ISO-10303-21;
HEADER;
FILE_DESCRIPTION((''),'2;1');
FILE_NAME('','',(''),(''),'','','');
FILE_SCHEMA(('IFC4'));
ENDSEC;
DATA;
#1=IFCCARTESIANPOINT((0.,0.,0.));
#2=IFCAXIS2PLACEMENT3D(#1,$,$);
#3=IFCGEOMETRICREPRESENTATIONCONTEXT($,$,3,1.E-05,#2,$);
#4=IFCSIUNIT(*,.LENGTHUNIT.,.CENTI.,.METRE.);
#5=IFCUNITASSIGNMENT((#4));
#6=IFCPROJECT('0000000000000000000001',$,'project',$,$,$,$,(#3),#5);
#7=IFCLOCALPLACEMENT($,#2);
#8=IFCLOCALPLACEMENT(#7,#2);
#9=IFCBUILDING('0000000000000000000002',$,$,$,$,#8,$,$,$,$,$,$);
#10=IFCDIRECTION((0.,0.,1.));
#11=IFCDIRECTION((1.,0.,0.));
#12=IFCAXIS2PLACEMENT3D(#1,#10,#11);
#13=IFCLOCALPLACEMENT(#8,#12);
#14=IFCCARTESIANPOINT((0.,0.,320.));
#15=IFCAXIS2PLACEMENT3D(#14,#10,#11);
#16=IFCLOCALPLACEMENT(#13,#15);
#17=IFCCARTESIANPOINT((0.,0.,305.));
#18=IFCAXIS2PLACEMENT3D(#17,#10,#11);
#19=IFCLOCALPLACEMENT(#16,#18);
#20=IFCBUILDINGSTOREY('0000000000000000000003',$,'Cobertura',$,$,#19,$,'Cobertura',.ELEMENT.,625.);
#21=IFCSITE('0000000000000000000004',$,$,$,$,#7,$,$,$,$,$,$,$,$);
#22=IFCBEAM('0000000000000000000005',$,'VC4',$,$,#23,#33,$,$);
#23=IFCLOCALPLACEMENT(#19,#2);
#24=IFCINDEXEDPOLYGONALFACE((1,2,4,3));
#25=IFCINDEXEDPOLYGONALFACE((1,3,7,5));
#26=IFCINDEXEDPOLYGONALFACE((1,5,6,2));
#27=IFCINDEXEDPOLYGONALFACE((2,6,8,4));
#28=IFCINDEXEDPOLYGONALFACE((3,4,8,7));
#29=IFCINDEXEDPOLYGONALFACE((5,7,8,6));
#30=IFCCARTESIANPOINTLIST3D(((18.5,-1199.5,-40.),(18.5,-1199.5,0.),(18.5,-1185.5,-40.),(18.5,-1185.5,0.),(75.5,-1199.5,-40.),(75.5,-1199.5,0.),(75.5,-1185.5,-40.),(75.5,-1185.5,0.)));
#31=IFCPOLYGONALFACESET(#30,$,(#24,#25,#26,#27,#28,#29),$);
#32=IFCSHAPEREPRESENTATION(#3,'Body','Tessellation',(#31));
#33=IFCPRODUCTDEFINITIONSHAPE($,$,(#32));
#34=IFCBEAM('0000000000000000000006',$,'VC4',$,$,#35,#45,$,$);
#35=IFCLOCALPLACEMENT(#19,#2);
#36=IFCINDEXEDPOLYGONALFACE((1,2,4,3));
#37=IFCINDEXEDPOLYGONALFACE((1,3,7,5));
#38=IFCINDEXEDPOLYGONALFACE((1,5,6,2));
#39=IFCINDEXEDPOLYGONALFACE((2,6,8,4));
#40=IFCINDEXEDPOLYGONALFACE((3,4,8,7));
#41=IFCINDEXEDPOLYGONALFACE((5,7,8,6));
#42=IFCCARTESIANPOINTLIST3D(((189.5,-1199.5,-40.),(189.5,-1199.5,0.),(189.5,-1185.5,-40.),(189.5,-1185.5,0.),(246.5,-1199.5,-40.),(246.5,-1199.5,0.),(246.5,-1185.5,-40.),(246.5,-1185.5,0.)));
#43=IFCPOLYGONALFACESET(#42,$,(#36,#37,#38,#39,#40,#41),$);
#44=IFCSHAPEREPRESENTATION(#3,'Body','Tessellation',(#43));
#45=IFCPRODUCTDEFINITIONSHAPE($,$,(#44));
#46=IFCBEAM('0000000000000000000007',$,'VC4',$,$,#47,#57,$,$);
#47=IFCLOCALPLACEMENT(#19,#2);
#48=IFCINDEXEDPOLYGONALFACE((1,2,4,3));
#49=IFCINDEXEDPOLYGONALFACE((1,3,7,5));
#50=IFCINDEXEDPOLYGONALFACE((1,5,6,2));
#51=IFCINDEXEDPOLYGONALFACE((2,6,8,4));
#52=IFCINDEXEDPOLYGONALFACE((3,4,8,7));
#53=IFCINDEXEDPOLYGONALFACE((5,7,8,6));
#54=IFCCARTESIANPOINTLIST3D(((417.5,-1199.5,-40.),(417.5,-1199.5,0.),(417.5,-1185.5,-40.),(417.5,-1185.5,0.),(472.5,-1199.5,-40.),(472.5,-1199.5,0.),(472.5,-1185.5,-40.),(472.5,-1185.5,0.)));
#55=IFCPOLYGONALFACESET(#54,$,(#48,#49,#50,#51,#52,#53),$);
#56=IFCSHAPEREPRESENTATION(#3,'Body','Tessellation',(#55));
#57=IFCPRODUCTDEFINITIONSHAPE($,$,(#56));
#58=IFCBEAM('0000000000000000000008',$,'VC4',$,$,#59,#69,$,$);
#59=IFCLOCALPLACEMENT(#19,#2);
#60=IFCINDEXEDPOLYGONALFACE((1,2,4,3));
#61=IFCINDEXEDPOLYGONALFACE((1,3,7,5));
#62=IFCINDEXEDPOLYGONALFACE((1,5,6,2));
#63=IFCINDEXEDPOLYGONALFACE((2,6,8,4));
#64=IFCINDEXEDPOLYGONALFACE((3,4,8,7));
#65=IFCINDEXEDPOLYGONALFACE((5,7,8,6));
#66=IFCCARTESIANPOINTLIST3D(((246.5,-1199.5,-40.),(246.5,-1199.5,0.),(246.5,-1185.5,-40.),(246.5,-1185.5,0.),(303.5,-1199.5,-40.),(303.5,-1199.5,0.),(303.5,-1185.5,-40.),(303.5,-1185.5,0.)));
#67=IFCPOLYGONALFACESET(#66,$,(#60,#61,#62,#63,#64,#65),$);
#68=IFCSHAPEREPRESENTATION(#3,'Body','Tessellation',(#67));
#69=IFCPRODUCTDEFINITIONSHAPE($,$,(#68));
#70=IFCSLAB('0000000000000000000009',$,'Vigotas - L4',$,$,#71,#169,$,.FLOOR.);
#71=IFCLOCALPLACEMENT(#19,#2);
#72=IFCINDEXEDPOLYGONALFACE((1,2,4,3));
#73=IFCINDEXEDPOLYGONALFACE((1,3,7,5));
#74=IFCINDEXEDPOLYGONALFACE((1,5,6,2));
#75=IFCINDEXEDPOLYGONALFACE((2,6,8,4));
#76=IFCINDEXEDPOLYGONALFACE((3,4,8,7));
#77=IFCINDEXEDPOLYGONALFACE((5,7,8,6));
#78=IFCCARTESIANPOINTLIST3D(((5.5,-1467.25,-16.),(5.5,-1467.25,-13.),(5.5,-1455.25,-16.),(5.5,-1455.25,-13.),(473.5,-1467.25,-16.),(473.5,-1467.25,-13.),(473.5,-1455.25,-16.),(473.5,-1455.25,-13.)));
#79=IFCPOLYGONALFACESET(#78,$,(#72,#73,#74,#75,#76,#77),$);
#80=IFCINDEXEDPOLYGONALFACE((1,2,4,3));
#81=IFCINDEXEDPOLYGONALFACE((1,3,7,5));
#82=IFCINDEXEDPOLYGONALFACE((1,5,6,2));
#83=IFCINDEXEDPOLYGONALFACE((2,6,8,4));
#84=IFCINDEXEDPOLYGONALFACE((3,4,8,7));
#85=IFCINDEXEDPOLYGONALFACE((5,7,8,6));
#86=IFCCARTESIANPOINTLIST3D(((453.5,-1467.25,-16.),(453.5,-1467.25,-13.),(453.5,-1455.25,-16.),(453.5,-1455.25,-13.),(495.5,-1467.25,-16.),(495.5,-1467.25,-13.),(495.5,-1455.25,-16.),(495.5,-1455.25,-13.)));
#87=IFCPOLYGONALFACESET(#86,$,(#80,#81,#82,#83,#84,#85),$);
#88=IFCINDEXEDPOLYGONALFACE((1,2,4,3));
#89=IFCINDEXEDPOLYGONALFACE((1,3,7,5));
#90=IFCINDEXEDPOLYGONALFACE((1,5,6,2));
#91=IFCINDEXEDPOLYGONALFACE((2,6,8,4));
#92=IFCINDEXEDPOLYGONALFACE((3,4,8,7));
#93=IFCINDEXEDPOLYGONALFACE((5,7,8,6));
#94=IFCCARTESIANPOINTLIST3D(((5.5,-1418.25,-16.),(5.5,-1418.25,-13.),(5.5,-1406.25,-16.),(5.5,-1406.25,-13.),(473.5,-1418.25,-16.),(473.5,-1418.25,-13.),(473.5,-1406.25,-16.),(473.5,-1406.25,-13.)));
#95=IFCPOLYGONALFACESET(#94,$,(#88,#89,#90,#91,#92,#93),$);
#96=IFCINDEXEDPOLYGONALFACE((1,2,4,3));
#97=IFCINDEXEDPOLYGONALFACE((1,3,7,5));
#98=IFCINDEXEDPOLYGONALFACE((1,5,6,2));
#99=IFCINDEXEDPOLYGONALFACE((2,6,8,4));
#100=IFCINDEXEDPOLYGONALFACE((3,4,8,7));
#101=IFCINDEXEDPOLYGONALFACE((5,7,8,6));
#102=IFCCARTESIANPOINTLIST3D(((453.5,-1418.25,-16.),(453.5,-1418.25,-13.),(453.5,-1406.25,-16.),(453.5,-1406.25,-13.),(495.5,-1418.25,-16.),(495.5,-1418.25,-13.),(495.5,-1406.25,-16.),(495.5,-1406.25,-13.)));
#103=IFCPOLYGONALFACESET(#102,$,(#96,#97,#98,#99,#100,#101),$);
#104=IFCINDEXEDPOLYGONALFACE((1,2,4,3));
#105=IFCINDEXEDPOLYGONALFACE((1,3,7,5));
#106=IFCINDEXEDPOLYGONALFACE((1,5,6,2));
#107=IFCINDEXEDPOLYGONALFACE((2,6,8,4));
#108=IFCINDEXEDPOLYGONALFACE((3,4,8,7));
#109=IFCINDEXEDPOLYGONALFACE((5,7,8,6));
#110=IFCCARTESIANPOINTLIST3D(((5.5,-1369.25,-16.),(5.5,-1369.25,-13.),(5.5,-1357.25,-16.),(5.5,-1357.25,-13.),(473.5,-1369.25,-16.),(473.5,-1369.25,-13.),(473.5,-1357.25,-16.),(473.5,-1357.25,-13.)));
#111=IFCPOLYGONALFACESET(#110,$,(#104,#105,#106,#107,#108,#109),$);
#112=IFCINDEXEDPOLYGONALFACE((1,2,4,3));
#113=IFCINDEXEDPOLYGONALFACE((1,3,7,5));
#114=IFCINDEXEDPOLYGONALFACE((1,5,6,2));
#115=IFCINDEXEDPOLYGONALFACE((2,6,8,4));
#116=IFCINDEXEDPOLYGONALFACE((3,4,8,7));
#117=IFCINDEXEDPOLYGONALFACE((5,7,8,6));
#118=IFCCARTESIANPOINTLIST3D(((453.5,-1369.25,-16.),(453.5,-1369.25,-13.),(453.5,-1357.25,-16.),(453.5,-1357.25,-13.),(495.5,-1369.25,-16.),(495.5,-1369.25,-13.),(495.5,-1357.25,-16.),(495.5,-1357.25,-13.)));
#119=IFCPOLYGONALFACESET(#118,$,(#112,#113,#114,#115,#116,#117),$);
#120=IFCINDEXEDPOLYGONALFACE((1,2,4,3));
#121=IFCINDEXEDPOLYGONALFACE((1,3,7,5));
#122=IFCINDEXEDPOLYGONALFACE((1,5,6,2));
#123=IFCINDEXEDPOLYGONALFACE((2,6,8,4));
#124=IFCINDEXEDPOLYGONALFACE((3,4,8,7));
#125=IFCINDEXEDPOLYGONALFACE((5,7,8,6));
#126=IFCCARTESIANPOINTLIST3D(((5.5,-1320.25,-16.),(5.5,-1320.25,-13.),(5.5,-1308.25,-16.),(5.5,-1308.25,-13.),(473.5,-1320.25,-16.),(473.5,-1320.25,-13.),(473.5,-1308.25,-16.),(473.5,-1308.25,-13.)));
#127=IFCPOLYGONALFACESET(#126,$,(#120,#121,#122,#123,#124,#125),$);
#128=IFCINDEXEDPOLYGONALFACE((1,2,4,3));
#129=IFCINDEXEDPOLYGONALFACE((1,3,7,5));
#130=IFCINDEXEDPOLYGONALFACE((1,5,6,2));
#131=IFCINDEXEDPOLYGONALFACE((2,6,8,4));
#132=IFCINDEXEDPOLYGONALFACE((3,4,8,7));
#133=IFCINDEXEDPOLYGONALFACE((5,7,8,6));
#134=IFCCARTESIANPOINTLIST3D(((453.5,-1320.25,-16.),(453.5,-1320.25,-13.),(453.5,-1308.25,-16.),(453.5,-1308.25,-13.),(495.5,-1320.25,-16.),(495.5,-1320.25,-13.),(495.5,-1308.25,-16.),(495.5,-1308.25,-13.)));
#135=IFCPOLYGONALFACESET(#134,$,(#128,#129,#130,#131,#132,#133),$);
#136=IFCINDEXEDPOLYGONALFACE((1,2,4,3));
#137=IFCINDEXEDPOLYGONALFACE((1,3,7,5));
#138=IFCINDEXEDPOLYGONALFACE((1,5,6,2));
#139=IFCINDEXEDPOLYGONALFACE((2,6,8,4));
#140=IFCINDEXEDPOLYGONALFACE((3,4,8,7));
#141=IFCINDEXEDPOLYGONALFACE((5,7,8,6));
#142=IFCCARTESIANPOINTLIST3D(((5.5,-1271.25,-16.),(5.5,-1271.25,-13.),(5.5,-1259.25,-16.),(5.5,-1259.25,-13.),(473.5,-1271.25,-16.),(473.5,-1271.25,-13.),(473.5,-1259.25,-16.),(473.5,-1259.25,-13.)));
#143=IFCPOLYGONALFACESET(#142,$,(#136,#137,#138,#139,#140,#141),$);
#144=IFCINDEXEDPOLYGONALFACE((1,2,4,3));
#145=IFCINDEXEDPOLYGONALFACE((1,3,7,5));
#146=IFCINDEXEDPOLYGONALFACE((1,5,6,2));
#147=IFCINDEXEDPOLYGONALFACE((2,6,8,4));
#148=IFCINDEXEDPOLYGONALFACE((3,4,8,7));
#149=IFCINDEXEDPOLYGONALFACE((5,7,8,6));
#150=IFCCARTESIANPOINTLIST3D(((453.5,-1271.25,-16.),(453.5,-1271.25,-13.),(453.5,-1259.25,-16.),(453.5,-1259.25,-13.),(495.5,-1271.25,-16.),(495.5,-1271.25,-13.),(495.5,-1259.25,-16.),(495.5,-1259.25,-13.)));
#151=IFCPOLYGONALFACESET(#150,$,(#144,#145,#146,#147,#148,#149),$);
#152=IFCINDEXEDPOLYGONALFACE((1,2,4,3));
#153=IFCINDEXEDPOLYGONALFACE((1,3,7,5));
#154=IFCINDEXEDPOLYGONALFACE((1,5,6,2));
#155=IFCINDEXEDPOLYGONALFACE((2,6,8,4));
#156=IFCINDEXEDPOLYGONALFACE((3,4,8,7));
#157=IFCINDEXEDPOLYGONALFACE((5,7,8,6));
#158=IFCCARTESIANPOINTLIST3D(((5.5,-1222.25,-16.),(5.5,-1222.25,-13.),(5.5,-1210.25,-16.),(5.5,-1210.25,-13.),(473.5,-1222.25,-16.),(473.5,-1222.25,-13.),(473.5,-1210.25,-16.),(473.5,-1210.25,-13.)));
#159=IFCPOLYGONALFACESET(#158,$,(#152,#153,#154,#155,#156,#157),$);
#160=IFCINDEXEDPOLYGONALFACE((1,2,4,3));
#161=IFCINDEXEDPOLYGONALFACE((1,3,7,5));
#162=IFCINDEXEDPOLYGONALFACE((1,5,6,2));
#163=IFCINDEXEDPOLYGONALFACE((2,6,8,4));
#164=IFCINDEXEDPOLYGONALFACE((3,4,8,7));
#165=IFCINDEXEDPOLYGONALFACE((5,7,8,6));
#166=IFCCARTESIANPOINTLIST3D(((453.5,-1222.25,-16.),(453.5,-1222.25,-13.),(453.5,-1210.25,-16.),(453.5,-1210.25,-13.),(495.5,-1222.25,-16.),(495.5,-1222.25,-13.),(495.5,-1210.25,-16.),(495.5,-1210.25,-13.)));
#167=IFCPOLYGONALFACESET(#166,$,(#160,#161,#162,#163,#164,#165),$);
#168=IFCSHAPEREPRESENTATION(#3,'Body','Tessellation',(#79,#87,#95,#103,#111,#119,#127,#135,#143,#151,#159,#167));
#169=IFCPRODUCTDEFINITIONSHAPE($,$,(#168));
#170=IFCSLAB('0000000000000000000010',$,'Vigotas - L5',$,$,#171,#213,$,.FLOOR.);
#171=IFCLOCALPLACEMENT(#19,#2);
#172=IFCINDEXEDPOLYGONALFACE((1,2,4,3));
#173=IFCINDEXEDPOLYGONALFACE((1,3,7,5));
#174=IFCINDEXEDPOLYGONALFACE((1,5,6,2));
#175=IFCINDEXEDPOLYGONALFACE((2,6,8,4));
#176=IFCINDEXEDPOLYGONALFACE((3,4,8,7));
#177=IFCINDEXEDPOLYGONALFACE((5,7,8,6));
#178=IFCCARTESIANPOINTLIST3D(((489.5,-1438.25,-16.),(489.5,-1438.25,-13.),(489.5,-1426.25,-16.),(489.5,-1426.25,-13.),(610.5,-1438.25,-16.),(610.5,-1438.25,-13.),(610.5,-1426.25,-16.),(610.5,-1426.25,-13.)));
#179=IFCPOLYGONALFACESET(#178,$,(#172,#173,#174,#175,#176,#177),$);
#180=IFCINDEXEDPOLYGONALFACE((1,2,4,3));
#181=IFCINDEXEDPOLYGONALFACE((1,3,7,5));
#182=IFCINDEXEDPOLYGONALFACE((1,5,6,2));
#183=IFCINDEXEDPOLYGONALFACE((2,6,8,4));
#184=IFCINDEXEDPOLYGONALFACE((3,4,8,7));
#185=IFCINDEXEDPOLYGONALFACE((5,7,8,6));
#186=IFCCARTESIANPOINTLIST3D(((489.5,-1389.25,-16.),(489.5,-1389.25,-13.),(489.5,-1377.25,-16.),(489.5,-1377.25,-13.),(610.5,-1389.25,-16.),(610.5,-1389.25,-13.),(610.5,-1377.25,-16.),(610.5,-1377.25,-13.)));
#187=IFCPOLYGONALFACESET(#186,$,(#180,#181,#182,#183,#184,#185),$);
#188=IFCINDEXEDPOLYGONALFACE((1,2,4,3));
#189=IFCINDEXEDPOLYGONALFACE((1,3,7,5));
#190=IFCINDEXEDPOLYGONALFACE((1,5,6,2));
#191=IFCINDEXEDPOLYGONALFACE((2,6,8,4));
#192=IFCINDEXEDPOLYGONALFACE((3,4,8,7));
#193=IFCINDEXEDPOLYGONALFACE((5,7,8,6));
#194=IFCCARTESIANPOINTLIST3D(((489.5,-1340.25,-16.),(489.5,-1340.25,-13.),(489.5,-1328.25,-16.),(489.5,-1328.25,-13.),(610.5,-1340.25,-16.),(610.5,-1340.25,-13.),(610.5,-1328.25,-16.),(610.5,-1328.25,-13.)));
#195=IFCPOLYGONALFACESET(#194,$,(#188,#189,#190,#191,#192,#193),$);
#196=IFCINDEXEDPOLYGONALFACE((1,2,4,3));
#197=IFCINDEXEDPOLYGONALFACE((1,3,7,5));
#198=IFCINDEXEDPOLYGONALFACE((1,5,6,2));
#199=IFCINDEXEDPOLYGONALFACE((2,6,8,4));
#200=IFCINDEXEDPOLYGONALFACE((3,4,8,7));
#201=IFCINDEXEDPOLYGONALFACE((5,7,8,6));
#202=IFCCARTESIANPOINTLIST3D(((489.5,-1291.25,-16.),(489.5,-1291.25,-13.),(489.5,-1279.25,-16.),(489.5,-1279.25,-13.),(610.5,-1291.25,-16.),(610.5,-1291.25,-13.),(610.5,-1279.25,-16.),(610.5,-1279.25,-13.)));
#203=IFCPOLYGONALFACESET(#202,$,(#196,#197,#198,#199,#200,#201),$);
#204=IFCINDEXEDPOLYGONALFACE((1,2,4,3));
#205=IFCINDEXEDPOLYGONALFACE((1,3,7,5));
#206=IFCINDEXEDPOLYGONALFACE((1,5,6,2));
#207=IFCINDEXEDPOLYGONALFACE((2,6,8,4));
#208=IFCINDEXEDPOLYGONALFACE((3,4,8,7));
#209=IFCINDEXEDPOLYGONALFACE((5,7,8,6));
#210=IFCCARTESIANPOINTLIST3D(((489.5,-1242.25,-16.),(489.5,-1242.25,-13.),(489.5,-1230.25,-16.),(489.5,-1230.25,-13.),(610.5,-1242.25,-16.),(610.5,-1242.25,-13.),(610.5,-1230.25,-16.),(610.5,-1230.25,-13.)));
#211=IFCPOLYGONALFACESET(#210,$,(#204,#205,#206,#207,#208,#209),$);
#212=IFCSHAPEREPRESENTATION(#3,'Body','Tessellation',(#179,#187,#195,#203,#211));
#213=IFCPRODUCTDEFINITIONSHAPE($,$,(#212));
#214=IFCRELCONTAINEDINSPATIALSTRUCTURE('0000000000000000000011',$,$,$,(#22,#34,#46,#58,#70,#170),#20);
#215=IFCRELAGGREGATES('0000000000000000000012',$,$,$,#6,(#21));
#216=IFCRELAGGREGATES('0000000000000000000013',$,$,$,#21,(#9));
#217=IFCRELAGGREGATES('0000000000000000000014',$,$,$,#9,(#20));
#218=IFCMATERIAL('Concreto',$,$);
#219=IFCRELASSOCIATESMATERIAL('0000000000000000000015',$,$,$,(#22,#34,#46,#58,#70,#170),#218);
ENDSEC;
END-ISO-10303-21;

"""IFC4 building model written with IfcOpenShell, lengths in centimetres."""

from ifc_helpers import new_model, si_unit, frame, origin, origin_with_axes, place, context, project, spatial, polyline, outline, extrude, material, element, save


model = new_model("IFC4")

# Units and contexts
context_of_model = context(None, 3, precision=1e-05, world=origin())
ifc_project = project(units=[si_unit("LENGTHUNIT", "METRE", prefix="CENTI")], contexts=[context_of_model])

# Site, building, storey
site_placement = place(None, origin())
site = spatial("IfcSite", under=ifc_project, at=site_placement)
building_placement = place(site_placement, origin())
building = spatial("IfcBuilding", under=site, at=building_placement)
placement_1 = place(building_placement, origin_with_axes())
placement_2 = place(placement_1, frame((0.0, 0.0, 320.0), z_axis=(0.0, 0.0, 1.0), x_axis=(1.0, 0.0, 0.0)))
storey_placement = place(placement_2, frame((0.0, 0.0, 305.0), z_axis=(0.0, 0.0, 1.0), x_axis=(1.0, 0.0, 0.0)))
storey = spatial("IfcBuildingStorey", under=building, at=storey_placement, Name="Cobertura", LongName="Cobertura", CompositionType="ELEMENT", Elevation=625.0)

# Shared definitions
ifc_material_1 = material(Name="Concreto")

# Beams
for number, where, z_axis, x_axis, name in (
    (1, (47.0, -1192.5, 0.0), (0.0, 0.0, 1.0), (1.0, 0.0, 0.0), "VC4"),
    (2, (218.0, -1192.5, 0.0), (0.0, 0.0, 1.0), (1.0, 0.0, 0.0), "VC4"),
):
    element("IfcBeam", number, at=place(storey_placement, frame(where, z_axis=z_axis, x_axis=x_axis)), inside=storey, material=ifc_material_1, Name=name, context=context_of_model, shape_type="SolidModel", body=[
        extrude(outline(polyline([(-7.0, -20.0), (7.0, -20.0), (7.0, 20.0), (-7.0, 20.0), (-7.0, -20.0)])), frame((-28.5, 0.0, -20.0), z_axis=(1.0, 0.0, 0.0), x_axis=(0.0, -1.0, 0.0)), (0.0, 0.0, 1.0), 57.0),
    ])
beam_1_placement = place(storey_placement, frame((445.0, -1192.5, 0.0), z_axis=(0.0, 0.0, 1.0), x_axis=(1.0, 0.0, 0.0)))
element("IfcBeam", 3, at=beam_1_placement, inside=storey, material=ifc_material_1, Name="VC4", context=context_of_model, shape_type="SolidModel", body=[
    extrude(outline(polyline([(-7.0, -20.0), (7.0, -20.0), (7.0, 20.0), (-7.0, 20.0), (-7.0, -20.0)])), frame((-27.5, 0.0, -20.0), z_axis=(1.0, 0.0, 0.0), x_axis=(0.0, -1.0, 0.0)), (0.0, 0.0, 1.0), 55.0),
])
beam_2_placement = place(storey_placement, frame((275.0, -1192.5, 0.0), z_axis=(0.0, 0.0, 1.0), x_axis=(1.0, 0.0, 0.0)))
element("IfcBeam", 4, at=beam_2_placement, inside=storey, material=ifc_material_1, Name="VC4", context=context_of_model, shape_type="SolidModel", body=[
    extrude(outline(polyline([(-7.0, -20.0), (7.0, -20.0), (7.0, 20.0), (-7.0, 20.0), (-7.0, -20.0)])), frame((-28.5, 0.0, -20.0), z_axis=(1.0, 0.0, 0.0), x_axis=(0.0, -1.0, 0.0)), (0.0, 0.0, 1.0), 57.0),
])

# Slabs
slab_1_placement = place(storey_placement, frame((250.5, -1338.75, -13.0), z_axis=(0.0, 0.0, 1.0), x_axis=(1.0, 0.0, 0.0)))
element("IfcSlab", 5, at=slab_1_placement, inside=storey, material=ifc_material_1, Name="Vigotas - L4", PredefinedType="FLOOR", context=context_of_model, shape_type="SolidModel", body=[
    extrude(outline(polyline([(6.0, 1.5), (-6.0, 1.5), (-6.0, -1.5), (6.0, -1.5), (6.0, 1.5), (6.0, 1.5)])), frame((-245.0, -122.5, -1.5), z_axis=(1.0, 0.0, 0.0), x_axis=(0.0, -1.0, 0.0)), (0.0, 0.0, 1.0), 468.0),
    extrude(outline(polyline([(6.0, 1.5), (-6.0, 1.5), (-6.0, -1.5), (6.0, -1.5), (6.0, 1.5), (6.0, 1.5)])), frame((203.0, -122.5, -1.5), z_axis=(1.0, 0.0, 0.0), x_axis=(0.0, -1.0, 0.0)), (0.0, 0.0, 1.0), 42.0),
    extrude(outline(polyline([(6.0, 1.5), (-6.0, 1.5), (-6.0, -1.5), (6.0, -1.5), (6.0, 1.5), (6.0, 1.5)])), frame((-245.0, -73.5, -1.5), z_axis=(1.0, 0.0, 0.0), x_axis=(0.0, -1.0, 0.0)), (0.0, 0.0, 1.0), 468.0),
    extrude(outline(polyline([(6.0, 1.5), (-6.0, 1.5), (-6.0, -1.5), (6.0, -1.5), (6.0, 1.5), (6.0, 1.5)])), frame((203.0, -73.5, -1.5), z_axis=(1.0, 0.0, 0.0), x_axis=(0.0, -1.0, 0.0)), (0.0, 0.0, 1.0), 42.0),
    extrude(outline(polyline([(6.0, 1.5), (-6.0, 1.5), (-6.0, -1.5), (6.0, -1.5), (6.0, 1.5), (6.0, 1.5)])), frame((-245.0, -24.5, -1.5), z_axis=(1.0, 0.0, 0.0), x_axis=(0.0, -1.0, 0.0)), (0.0, 0.0, 1.0), 468.0),
    extrude(outline(polyline([(6.0, 1.5), (-6.0, 1.5), (-6.0, -1.5), (6.0, -1.5), (6.0, 1.5), (6.0, 1.5)])), frame((203.0, -24.5, -1.5), z_axis=(1.0, 0.0, 0.0), x_axis=(0.0, -1.0, 0.0)), (0.0, 0.0, 1.0), 42.0),
    extrude(outline(polyline([(6.0, 1.5), (-6.0, 1.5), (-6.0, -1.5), (6.0, -1.5), (6.0, 1.5), (6.0, 1.5)])), frame((-245.0, 24.5, -1.5), z_axis=(1.0, 0.0, 0.0), x_axis=(0.0, -1.0, 0.0)), (0.0, 0.0, 1.0), 468.0),
    extrude(outline(polyline([(6.0, 1.5), (-6.0, 1.5), (-6.0, -1.5), (6.0, -1.5), (6.0, 1.5), (6.0, 1.5)])), frame((203.0, 24.5, -1.5), z_axis=(1.0, 0.0, 0.0), x_axis=(0.0, -1.0, 0.0)), (0.0, 0.0, 1.0), 42.0),
    extrude(outline(polyline([(6.0, 1.5), (-6.0, 1.5), (-6.0, -1.5), (6.0, -1.5), (6.0, 1.5), (6.0, 1.5)])), frame((-245.0, 73.5, -1.5), z_axis=(1.0, 0.0, 0.0), x_axis=(0.0, -1.0, 0.0)), (0.0, 0.0, 1.0), 468.0),
    extrude(outline(polyline([(6.0, 1.5), (-6.0, 1.5), (-6.0, -1.5), (6.0, -1.5), (6.0, 1.5), (6.0, 1.5)])), frame((203.0, 73.5, -1.5), z_axis=(1.0, 0.0, 0.0), x_axis=(0.0, -1.0, 0.0)), (0.0, 0.0, 1.0), 42.0),
    extrude(outline(polyline([(6.0, 1.5), (-6.0, 1.5), (-6.0, -1.5), (6.0, -1.5), (6.0, 1.5), (6.0, 1.5)])), frame((-245.0, 122.5, -1.5), z_axis=(1.0, 0.0, 0.0), x_axis=(0.0, -1.0, 0.0)), (0.0, 0.0, 1.0), 468.0),
    extrude(outline(polyline([(6.0, 1.5), (-6.0, 1.5), (-6.0, -1.5), (6.0, -1.5), (6.0, 1.5), (6.0, 1.5)])), frame((203.0, 122.5, -1.5), z_axis=(1.0, 0.0, 0.0), x_axis=(0.0, -1.0, 0.0)), (0.0, 0.0, 1.0), 42.0),
])
slab_2_placement = place(storey_placement, frame((550.0, -1334.25, -13.0), z_axis=(0.0, 0.0, 1.0), x_axis=(1.0, 0.0, 0.0)))
element("IfcSlab", 6, at=slab_2_placement, inside=storey, material=ifc_material_1, Name="Vigotas - L5", PredefinedType="FLOOR", context=context_of_model, shape_type="SolidModel", body=[
    extrude(outline(polyline([(6.0, 1.5), (-6.0, 1.5), (-6.0, -1.5), (6.0, -1.5), (6.0, 1.5), (6.0, 1.5)])), frame((-60.5, -98.0, -1.5), z_axis=(1.0, 0.0, 0.0), x_axis=(0.0, -1.0, 0.0)), (0.0, 0.0, 1.0), 121.0),
    extrude(outline(polyline([(6.0, 1.5), (-6.0, 1.5), (-6.0, -1.5), (6.0, -1.5), (6.0, 1.5), (6.0, 1.5)])), frame((-60.5, -49.0, -1.5), z_axis=(1.0, 0.0, 0.0), x_axis=(0.0, -1.0, 0.0)), (0.0, 0.0, 1.0), 121.0),
    extrude(outline(polyline([(6.0, 1.5), (-6.0, 1.5), (-6.0, -1.5), (6.0, -1.5), (6.0, 1.5), (6.0, 1.5)])), frame((-60.5, 0.0, -1.5), z_axis=(1.0, 0.0, 0.0), x_axis=(0.0, -1.0, 0.0)), (0.0, 0.0, 1.0), 121.0),
    extrude(outline(polyline([(6.0, 1.5), (-6.0, 1.5), (-6.0, -1.5), (6.0, -1.5), (6.0, 1.5), (6.0, 1.5)])), frame((-60.5, 49.0, -1.5), z_axis=(1.0, 0.0, 0.0), x_axis=(0.0, -1.0, 0.0)), (0.0, 0.0, 1.0), 121.0),
    extrude(outline(polyline([(6.0, 1.5), (-6.0, 1.5), (-6.0, -1.5), (6.0, -1.5), (6.0, 1.5), (6.0, 1.5)])), frame((-60.5, 98.0, -1.5), z_axis=(1.0, 0.0, 0.0), x_axis=(0.0, -1.0, 0.0)), (0.0, 0.0, 1.0), 121.0),
])

save(model, "model.ifc")
